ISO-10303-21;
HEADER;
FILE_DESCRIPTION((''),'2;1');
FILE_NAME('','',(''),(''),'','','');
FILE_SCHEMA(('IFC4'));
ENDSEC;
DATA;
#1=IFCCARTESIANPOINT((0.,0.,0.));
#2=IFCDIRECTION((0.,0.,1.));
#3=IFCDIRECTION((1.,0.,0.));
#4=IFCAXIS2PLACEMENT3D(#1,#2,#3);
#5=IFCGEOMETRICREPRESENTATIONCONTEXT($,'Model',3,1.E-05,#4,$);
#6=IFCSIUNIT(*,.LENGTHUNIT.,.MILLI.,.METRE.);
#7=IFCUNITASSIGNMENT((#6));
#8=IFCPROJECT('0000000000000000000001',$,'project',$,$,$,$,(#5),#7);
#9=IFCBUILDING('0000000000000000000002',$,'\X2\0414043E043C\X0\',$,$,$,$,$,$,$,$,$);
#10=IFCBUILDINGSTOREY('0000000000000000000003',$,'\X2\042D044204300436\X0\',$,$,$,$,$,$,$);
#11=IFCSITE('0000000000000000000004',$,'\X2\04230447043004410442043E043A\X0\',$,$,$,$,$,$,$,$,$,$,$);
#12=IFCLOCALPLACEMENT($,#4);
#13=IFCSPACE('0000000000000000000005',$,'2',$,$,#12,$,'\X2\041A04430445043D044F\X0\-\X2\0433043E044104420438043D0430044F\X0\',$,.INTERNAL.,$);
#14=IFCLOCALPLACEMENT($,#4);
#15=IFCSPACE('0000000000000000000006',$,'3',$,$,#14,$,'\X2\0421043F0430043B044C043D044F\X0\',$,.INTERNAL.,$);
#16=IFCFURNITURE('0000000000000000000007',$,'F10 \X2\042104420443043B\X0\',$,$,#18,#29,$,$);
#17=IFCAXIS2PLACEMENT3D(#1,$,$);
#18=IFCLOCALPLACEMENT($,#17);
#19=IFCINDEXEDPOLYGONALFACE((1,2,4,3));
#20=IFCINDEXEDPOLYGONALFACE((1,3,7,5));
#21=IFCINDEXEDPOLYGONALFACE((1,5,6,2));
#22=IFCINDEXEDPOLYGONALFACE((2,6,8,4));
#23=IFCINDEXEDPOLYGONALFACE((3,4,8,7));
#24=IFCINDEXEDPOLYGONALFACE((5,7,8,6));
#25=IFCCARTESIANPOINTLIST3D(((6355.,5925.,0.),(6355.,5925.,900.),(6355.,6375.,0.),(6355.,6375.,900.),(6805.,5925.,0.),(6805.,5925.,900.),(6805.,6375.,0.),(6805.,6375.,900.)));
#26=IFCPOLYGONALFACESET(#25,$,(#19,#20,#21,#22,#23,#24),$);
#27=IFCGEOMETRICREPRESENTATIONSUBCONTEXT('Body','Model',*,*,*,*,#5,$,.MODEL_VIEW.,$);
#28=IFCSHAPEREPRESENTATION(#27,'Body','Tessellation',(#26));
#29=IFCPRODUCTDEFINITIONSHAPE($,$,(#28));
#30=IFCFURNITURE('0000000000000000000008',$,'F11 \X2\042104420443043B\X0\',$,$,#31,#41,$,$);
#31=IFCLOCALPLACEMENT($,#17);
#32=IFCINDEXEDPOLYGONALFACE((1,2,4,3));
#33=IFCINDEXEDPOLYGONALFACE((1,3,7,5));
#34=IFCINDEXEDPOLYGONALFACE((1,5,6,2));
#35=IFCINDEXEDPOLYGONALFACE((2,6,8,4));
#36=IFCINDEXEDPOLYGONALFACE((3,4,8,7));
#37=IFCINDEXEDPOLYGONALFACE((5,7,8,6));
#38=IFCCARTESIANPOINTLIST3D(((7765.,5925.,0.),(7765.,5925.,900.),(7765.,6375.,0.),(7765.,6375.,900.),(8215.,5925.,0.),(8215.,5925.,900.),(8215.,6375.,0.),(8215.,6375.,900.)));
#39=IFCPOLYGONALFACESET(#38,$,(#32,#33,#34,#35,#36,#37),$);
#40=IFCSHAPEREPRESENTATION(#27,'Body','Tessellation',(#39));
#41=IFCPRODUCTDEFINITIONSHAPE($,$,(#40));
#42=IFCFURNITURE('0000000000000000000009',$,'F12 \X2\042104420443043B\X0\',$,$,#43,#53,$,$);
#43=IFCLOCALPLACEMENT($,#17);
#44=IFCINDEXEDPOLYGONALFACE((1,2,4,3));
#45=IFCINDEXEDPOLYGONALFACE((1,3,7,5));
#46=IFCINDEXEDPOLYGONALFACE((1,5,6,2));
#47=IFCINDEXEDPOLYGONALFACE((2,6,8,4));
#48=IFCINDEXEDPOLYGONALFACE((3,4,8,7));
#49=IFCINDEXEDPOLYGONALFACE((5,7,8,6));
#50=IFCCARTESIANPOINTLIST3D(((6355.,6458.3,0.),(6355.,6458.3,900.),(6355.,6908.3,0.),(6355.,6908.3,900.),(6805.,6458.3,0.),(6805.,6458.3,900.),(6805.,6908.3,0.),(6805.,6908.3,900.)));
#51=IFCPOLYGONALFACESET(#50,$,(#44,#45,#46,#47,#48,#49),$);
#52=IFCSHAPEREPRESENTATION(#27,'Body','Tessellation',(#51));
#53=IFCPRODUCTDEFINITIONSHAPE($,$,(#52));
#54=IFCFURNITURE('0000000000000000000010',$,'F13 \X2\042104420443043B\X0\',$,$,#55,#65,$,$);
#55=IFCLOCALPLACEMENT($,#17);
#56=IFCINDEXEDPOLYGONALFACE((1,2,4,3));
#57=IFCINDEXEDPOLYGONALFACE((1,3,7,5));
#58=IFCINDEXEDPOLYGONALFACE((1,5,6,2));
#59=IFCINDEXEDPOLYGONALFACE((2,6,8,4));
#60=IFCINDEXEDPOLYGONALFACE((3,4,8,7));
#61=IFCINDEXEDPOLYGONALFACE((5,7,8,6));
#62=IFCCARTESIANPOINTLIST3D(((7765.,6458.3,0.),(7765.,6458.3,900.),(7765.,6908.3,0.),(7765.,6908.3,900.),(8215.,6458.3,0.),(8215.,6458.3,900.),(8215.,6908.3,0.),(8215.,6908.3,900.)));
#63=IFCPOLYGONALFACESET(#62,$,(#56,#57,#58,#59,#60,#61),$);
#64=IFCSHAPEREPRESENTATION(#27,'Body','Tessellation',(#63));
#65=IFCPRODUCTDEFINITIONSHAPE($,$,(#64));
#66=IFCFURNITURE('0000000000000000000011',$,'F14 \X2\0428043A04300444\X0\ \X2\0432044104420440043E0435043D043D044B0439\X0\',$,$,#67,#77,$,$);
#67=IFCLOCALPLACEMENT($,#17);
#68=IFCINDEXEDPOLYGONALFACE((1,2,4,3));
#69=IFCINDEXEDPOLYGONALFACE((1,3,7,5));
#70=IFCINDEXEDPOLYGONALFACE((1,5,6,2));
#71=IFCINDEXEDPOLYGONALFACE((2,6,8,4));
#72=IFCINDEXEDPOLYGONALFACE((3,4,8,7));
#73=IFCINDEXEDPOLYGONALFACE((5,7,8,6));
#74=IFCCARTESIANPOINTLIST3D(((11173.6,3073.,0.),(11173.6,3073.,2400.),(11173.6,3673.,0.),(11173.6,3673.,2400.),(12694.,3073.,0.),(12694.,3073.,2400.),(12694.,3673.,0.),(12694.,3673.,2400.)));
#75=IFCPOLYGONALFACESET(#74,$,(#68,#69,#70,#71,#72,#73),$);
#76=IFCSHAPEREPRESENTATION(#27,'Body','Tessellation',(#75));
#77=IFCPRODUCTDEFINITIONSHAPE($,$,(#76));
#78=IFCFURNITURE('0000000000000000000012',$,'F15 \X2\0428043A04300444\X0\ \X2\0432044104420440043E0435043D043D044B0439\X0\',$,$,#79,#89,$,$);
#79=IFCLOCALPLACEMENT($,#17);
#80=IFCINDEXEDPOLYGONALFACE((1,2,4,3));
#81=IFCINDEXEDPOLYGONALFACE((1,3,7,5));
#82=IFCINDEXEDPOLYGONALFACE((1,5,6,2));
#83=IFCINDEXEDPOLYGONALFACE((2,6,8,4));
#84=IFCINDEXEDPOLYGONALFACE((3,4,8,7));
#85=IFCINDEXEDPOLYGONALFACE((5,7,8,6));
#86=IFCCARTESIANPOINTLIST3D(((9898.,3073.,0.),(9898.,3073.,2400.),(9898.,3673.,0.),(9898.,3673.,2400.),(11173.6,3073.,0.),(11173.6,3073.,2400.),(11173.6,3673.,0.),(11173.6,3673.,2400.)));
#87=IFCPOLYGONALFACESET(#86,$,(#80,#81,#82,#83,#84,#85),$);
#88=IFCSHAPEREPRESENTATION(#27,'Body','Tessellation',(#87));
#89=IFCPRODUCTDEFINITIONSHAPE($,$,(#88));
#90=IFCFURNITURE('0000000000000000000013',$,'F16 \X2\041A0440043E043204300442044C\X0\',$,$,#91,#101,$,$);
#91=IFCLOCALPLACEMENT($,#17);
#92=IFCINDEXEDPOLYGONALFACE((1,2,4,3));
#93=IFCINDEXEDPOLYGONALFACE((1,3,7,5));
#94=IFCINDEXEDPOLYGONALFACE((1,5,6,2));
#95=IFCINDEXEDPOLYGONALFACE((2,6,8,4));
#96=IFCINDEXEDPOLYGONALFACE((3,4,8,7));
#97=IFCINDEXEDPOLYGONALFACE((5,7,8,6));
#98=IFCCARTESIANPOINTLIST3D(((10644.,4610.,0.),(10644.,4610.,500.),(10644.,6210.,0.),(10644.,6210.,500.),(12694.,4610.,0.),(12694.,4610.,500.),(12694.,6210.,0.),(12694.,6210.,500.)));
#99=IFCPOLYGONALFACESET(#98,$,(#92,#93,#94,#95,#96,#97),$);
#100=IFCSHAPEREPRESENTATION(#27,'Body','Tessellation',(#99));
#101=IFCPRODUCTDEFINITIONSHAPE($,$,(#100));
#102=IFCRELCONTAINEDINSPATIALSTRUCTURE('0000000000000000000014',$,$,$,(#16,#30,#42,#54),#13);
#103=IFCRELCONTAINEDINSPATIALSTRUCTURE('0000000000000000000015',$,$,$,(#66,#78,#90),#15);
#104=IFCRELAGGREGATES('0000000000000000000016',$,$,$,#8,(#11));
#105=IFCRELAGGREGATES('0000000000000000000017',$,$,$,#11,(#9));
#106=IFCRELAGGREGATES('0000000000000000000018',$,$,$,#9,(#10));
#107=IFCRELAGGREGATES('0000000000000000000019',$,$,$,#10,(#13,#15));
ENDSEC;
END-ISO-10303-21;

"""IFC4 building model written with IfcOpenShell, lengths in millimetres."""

from ifc_helpers import new_model, si_unit, origin, origin_with_axes, place, context, subcontext, project, spatial, polyline, outline, extrude, element, save


model = new_model("IFC4")

# Units and contexts
model_context = context("Model", 3, precision=1e-05, world=origin_with_axes())
body_context = subcontext(model_context, "Body", "Model", "MODEL_VIEW")
ifc_project = project(units=[si_unit("LENGTHUNIT", "METRE", prefix="MILLI")], contexts=[model_context])

# Site, building, storey
site = spatial("IfcSite", under=ifc_project, Name="Участок")
building = spatial("IfcBuilding", under=site, Name="Дом")
storey = spatial("IfcBuildingStorey", under=building, Name="Этаж")

# Shared definitions
space_1_placement = place(None, origin_with_axes())
space_1 = spatial("IfcSpace", under=storey, at=space_1_placement, Name="2", LongName="Кухня-гостиная", PredefinedType="INTERNAL")

# Furniture
furniture_1_placement = place(space_1_placement, origin_with_axes())
element("IfcFurniture", 1, at=furniture_1_placement, inside=space_1, Name="F10 Стул", context=body_context, shape_type="SweptSolid", body=[
    extrude(outline(polyline([(6805.0, 5925.0), (6805.0, 6375.0), (6355.0, 6375.0), (6355.0, 5925.0), (6805.0, 5925.0)])), origin(), (0.0, 0.0, 1.0), 900.0),
])
furniture_2_placement = place(space_1_placement, origin_with_axes())
element("IfcFurniture", 2, at=furniture_2_placement, inside=space_1, Name="F11 Стул", context=body_context, shape_type="SweptSolid", body=[
    extrude(outline(polyline([(8215.0, 5925.0), (8215.0, 6375.0), (7765.0, 6375.0), (7765.0, 5925.0), (8215.0, 5925.0)])), origin(), (0.0, 0.0, 1.0), 900.0),
])
furniture_3_placement = place(space_1_placement, origin_with_axes())
element("IfcFurniture", 3, at=furniture_3_placement, inside=space_1, Name="F12 Стул", context=body_context, shape_type="SweptSolid", body=[
    extrude(outline(polyline([(6805.0, 6458.3), (6805.0, 6908.3), (6355.0, 6908.3), (6355.0, 6458.3), (6805.0, 6458.3)])), origin(), (0.0, 0.0, 1.0), 900.0),
])
furniture_4_placement = place(space_1_placement, origin_with_axes())
element("IfcFurniture", 4, at=furniture_4_placement, inside=space_1, Name="F13 Стул", context=body_context, shape_type="SweptSolid", body=[
    extrude(outline(polyline([(8215.0, 6458.3), (8215.0, 6908.3), (7765.0, 6908.3), (7765.0, 6458.3), (8215.0, 6458.3)])), origin(), (0.0, 0.0, 1.0), 900.0),
])

# Shared definitions
space_2_placement = place(None, origin_with_axes())
space_2 = spatial("IfcSpace", under=storey, at=space_2_placement, Name="3", LongName="Спальня", PredefinedType="INTERNAL")

# Furniture
furniture_5_placement = place(space_2_placement, origin_with_axes())
element("IfcFurniture", 5, at=furniture_5_placement, inside=space_2, Name="F14 Шкаф встроенный", context=body_context, shape_type="SweptSolid", body=[
    extrude(outline(polyline([(12694.0, 3073.0), (12694.0, 3673.0), (11173.6, 3673.0), (11173.6, 3073.0), (12694.0, 3073.0)])), origin(), (0.0, 0.0, 1.0), 2400.0),
])
furniture_6_placement = place(space_2_placement, origin_with_axes())
element("IfcFurniture", 6, at=furniture_6_placement, inside=space_2, Name="F15 Шкаф встроенный", context=body_context, shape_type="SweptSolid", body=[
    extrude(outline(polyline([(11173.6, 3073.0), (11173.6, 3673.0), (9898.0, 3673.0), (9898.0, 3073.0), (11173.6, 3073.0)])), origin(), (0.0, 0.0, 1.0), 2400.0),
])
furniture_7_placement = place(space_2_placement, origin_with_axes())
element("IfcFurniture", 7, at=furniture_7_placement, inside=space_2, Name="F16 Кровать", context=body_context, shape_type="SweptSolid", body=[
    extrude(outline(polyline([(12694.0, 6210.0), (12694.0, 4610.0), (10644.0, 4610.0), (10644.0, 6210.0), (12694.0, 6210.0)])), origin(), (0.0, 0.0, 1.0), 500.0),
])

save(model, "model.ifc")
